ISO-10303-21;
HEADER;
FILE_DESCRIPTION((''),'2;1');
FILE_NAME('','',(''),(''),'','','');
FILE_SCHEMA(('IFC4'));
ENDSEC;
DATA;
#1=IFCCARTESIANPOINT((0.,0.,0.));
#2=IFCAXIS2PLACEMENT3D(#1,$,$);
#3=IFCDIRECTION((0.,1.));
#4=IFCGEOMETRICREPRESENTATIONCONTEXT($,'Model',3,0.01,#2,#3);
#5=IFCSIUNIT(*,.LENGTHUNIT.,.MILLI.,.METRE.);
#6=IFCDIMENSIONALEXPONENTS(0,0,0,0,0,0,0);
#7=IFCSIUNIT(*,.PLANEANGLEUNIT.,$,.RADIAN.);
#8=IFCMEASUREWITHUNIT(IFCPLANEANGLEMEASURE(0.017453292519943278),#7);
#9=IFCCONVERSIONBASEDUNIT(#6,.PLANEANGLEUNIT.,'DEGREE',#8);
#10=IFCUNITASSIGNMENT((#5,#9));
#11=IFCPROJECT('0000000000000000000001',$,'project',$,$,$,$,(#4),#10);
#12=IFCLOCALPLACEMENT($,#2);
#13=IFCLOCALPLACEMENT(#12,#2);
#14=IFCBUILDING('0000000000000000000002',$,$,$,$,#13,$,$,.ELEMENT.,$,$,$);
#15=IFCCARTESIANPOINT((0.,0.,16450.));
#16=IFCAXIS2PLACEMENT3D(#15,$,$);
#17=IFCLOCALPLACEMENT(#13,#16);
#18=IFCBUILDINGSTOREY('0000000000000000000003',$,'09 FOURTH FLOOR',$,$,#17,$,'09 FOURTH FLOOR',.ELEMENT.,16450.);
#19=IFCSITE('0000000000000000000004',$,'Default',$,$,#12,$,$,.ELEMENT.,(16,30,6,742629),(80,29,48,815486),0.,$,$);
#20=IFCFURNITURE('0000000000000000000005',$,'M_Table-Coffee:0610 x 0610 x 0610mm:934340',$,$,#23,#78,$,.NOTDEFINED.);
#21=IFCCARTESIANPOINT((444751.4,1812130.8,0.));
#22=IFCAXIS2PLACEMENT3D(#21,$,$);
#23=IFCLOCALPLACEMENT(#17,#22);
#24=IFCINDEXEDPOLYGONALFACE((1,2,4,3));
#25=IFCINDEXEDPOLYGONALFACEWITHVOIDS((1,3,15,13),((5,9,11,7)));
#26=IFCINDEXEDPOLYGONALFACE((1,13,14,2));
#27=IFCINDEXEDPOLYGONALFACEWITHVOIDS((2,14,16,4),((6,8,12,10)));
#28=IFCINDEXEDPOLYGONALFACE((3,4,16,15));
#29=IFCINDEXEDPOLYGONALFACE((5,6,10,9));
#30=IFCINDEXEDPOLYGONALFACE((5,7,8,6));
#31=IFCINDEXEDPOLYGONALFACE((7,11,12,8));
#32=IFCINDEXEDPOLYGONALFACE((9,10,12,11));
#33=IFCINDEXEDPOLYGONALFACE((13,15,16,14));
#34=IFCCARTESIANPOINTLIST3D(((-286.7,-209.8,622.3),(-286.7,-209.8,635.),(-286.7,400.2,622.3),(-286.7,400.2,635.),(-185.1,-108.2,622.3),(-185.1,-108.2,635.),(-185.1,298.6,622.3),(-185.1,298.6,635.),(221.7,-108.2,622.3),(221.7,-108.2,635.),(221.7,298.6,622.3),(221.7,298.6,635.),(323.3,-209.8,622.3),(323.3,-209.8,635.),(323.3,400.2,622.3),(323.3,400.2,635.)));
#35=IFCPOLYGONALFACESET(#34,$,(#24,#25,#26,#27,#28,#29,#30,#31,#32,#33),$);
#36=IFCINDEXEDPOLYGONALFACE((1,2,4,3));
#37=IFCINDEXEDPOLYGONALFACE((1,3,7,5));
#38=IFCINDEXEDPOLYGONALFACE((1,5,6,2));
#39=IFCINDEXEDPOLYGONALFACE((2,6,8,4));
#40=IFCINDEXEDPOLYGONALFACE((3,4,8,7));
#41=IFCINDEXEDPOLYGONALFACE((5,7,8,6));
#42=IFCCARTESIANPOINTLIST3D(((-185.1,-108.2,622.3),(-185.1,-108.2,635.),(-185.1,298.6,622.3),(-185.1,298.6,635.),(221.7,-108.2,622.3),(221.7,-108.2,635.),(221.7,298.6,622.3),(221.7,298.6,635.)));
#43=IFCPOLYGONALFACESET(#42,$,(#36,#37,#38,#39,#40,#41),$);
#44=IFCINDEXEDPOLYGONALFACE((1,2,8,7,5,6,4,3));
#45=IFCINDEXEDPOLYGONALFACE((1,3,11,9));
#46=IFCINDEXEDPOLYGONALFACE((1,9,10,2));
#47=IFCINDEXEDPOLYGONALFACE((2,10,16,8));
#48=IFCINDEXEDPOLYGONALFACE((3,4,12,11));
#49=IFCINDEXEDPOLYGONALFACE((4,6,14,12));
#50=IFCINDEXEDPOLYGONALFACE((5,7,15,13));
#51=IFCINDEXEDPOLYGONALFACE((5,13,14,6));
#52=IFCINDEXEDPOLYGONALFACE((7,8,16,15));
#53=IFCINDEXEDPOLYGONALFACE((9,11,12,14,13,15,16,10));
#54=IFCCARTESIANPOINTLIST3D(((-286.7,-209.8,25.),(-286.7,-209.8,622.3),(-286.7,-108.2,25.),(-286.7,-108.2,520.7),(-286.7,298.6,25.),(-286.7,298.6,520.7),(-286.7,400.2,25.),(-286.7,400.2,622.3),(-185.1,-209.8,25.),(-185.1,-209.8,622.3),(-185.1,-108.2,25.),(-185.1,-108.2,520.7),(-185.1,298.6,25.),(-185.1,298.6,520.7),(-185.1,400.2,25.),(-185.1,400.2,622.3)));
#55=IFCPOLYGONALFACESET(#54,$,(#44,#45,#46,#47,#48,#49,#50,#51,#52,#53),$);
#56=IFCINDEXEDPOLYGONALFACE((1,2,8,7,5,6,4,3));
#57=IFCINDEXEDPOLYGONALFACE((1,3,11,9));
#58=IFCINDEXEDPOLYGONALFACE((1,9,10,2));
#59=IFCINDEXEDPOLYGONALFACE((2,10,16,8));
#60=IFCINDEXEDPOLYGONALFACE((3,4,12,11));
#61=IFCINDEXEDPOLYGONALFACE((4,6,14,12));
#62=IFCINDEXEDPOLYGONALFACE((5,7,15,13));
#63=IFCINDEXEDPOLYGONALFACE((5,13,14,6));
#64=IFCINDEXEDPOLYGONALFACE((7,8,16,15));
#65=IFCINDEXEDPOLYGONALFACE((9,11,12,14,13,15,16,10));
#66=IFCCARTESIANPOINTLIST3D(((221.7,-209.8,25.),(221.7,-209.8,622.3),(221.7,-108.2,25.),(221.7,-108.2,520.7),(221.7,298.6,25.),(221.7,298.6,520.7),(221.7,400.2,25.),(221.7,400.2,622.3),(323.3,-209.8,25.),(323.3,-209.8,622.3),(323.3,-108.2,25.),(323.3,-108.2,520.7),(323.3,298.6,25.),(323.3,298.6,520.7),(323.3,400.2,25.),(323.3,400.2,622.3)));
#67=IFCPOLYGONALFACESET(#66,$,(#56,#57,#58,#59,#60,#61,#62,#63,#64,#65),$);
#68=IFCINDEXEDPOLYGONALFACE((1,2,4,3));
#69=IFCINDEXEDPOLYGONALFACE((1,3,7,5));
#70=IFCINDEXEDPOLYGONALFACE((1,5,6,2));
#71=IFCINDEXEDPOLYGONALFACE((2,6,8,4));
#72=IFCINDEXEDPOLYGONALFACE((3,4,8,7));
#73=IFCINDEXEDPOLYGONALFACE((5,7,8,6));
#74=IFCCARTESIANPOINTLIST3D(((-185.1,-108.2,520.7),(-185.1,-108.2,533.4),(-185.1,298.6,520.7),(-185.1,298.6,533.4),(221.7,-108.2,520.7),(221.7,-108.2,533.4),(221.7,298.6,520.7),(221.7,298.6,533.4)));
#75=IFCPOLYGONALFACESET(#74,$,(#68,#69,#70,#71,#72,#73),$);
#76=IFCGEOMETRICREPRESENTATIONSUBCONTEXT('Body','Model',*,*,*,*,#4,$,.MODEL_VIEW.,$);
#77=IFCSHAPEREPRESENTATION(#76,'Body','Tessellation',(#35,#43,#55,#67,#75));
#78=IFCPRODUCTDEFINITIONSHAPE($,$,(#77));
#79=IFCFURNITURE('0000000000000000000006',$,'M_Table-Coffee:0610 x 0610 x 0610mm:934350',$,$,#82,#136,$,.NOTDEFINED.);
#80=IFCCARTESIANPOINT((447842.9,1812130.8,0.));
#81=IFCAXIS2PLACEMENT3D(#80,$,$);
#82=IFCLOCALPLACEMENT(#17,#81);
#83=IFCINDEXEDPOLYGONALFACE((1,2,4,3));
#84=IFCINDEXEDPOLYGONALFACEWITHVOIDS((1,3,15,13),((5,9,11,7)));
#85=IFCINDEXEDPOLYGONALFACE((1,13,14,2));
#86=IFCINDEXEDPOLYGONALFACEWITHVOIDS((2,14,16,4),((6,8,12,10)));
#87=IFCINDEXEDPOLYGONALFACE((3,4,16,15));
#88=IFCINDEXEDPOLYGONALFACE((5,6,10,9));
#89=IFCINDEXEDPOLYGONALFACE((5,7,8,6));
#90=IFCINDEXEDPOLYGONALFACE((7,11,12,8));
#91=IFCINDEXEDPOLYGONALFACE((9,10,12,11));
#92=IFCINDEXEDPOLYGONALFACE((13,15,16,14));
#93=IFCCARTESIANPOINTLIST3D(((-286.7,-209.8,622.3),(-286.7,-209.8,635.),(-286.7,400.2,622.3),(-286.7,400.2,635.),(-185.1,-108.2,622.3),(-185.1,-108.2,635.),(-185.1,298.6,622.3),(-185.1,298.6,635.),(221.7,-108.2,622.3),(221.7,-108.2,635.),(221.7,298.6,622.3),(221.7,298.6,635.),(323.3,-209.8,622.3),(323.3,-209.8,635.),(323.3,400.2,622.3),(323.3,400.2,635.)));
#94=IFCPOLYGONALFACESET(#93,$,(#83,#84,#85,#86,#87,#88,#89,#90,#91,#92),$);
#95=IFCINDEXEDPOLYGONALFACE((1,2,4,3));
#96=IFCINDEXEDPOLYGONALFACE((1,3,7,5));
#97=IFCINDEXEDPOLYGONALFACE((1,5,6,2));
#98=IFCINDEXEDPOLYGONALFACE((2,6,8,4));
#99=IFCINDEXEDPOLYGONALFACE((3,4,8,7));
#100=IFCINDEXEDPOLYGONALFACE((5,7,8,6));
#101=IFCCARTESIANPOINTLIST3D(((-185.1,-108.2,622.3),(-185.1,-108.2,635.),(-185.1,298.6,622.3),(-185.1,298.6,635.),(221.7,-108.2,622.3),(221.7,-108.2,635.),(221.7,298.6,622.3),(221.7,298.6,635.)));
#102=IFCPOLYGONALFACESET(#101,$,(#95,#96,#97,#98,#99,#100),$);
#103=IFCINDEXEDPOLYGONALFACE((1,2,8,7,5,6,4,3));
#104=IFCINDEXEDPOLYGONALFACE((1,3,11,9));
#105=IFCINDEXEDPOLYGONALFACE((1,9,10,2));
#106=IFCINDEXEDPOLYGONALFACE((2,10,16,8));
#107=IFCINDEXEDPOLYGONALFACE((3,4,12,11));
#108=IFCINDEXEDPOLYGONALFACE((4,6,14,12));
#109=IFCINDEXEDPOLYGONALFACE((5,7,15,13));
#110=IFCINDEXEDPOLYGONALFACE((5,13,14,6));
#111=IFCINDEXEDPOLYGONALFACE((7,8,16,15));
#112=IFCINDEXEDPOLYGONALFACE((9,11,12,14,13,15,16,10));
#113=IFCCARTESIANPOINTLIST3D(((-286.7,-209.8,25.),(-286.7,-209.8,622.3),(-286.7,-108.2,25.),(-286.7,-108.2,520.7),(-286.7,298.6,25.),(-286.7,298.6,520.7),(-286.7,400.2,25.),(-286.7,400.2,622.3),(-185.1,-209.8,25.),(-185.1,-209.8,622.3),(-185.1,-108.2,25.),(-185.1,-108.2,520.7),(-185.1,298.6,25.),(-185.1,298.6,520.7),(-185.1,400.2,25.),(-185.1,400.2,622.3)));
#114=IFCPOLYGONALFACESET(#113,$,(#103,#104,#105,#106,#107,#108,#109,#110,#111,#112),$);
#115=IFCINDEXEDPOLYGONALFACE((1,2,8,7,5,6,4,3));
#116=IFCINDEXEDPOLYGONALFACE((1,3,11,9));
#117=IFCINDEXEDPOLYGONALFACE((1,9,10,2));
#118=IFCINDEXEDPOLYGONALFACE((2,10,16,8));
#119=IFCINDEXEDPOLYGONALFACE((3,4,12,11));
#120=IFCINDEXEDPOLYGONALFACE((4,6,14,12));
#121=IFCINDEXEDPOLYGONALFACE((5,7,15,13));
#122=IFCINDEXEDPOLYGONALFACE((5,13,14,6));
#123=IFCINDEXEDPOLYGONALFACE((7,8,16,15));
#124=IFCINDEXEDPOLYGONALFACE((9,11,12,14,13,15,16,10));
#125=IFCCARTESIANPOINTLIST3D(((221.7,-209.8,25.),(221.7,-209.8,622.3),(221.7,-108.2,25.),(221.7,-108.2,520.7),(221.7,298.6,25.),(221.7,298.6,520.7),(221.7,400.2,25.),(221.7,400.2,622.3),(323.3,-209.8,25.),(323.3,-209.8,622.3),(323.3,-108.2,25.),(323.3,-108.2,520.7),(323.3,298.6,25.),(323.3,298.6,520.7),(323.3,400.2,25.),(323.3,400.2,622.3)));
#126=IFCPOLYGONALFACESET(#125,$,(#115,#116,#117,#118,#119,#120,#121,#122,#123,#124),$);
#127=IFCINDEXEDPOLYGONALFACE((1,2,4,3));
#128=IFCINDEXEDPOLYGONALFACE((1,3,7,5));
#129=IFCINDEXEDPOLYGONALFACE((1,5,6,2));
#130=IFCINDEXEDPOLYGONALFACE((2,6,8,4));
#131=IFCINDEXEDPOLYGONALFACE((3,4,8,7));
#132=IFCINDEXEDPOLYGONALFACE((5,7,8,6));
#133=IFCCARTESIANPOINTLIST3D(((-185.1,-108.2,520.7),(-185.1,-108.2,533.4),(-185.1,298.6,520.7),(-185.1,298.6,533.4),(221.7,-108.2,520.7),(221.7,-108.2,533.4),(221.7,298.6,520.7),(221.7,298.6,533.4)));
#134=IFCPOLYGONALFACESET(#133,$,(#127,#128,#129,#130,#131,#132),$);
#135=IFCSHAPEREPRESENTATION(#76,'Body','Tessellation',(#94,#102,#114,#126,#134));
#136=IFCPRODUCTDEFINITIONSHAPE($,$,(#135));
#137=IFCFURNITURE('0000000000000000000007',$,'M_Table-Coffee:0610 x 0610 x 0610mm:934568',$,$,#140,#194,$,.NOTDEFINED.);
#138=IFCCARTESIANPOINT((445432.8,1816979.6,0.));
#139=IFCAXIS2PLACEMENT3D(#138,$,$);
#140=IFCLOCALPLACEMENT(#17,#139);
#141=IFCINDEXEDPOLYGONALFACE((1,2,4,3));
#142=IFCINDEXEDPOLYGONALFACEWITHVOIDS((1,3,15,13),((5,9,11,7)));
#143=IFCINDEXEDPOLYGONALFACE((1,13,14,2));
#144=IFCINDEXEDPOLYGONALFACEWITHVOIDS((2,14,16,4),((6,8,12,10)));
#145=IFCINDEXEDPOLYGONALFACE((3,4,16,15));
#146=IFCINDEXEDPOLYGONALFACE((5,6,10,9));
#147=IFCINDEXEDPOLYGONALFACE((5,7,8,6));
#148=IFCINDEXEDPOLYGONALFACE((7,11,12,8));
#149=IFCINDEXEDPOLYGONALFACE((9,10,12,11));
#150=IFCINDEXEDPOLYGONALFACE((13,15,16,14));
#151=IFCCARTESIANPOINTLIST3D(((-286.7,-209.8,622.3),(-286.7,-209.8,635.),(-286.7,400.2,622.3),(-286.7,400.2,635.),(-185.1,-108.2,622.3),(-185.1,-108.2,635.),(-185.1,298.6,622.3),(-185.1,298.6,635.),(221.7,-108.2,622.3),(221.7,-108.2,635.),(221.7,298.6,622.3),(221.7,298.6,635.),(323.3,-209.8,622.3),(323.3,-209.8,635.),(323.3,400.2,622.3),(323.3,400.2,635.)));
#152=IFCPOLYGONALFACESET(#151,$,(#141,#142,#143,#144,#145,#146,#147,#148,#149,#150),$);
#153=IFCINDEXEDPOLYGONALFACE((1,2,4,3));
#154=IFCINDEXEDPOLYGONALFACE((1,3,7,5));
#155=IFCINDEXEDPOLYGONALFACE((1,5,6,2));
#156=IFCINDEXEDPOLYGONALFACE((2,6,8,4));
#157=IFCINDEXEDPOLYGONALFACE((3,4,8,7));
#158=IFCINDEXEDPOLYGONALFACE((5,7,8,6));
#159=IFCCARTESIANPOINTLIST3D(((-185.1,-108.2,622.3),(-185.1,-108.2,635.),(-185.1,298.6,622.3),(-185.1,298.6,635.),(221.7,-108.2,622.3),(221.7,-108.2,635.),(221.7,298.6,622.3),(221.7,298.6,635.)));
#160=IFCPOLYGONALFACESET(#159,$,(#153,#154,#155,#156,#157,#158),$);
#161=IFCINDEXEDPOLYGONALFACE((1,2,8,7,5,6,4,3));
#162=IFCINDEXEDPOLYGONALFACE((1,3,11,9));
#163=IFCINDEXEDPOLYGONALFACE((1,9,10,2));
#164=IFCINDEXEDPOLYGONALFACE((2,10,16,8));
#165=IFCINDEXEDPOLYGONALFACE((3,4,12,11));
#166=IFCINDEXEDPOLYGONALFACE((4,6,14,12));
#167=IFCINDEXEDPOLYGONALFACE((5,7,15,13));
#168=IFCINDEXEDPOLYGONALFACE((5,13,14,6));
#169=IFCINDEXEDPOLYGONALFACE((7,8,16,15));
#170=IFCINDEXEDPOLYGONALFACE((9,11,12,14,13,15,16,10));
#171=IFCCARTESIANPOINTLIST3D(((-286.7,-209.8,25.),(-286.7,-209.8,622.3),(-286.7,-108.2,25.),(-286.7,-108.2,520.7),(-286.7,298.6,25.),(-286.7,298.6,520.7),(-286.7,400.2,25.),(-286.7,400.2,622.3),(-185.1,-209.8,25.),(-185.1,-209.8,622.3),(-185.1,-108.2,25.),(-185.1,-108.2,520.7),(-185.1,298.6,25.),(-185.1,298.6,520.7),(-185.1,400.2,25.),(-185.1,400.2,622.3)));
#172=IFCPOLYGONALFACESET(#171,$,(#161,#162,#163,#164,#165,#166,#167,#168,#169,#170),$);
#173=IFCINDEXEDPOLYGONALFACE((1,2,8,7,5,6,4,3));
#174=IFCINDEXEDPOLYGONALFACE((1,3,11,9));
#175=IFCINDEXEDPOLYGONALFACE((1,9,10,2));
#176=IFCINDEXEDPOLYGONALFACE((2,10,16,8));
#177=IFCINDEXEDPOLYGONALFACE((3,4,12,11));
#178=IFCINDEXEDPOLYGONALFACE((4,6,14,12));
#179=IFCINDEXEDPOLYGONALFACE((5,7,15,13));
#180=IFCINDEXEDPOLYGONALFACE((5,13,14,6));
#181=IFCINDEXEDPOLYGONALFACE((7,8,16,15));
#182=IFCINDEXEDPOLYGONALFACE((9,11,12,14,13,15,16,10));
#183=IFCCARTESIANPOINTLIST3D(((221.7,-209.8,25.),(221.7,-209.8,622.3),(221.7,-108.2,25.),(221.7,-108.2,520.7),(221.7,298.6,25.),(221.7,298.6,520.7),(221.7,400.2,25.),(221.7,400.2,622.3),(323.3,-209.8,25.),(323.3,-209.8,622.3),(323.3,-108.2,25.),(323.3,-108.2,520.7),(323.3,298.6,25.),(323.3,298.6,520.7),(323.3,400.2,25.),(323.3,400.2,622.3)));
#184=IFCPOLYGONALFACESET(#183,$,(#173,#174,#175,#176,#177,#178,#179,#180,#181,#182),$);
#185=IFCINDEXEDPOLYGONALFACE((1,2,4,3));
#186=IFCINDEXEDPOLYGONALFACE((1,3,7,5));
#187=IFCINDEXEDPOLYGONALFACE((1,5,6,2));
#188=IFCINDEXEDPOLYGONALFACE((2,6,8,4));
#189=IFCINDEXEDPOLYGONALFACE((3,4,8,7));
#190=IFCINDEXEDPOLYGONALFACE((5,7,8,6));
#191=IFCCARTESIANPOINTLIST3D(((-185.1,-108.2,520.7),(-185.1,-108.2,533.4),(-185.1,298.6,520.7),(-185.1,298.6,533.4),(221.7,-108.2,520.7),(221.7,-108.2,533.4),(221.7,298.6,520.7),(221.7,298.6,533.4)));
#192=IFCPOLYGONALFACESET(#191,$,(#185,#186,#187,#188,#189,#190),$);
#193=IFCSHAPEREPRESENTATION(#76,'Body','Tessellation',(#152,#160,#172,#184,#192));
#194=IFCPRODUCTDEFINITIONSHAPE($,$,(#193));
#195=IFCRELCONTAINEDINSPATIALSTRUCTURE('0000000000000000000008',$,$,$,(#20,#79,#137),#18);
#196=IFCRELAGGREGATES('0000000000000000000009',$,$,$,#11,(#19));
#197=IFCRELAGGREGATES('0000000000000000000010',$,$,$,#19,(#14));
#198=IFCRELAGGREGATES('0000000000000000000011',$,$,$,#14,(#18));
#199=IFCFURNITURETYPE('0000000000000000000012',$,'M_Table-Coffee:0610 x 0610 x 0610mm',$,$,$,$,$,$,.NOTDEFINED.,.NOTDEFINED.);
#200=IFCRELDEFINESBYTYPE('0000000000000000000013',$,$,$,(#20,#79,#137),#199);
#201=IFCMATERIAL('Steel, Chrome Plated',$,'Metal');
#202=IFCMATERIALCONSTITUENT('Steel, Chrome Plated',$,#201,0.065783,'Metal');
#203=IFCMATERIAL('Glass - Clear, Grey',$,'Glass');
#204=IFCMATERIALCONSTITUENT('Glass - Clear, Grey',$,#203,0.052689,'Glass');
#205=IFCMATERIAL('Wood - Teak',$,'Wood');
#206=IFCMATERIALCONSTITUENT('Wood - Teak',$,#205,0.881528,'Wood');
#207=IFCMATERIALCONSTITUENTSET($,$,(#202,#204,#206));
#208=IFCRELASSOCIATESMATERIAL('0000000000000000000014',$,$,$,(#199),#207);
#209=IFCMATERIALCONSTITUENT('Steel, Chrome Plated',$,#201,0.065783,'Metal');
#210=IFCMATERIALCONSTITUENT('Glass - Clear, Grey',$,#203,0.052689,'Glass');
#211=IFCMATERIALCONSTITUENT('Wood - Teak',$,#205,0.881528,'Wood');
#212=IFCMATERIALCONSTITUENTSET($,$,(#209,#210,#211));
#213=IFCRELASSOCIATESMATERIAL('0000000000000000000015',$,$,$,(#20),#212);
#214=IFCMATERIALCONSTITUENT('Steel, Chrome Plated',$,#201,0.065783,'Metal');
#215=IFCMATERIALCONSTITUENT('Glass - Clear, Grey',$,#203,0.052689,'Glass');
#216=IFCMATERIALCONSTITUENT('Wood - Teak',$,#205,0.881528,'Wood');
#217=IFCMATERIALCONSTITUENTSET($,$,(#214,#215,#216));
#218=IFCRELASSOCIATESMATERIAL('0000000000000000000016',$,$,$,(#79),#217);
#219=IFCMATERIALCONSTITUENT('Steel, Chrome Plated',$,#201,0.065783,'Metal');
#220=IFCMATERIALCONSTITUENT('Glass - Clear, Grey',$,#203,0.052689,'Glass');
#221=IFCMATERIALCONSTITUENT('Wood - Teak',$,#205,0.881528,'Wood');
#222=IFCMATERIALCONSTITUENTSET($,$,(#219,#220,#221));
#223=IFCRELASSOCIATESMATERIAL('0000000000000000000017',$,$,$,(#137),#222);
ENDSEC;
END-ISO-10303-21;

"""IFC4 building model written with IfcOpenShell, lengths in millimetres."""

from ifc_helpers import new_model, entity, si_unit, converted_unit, direction, frame, origin, place, context, subcontext, project, spatial, indexed_curve, outline, extrude, source, transform, mapped, material, constituent, constituent_set, type_object, type_shapes, element, save


model = new_model("IFC4")

# Units and contexts
model_context = context("Model", 3, precision=0.01, world=origin(), true_north=direction((0.0, 1.0)))
body_context = subcontext(model_context, "Body", "Model", "MODEL_VIEW")
ifc_project = project(units=[si_unit("LENGTHUNIT", "METRE", prefix="MILLI"), converted_unit("PLANEANGLEUNIT", "DEGREE", entity("IfcPlaneAngleMeasure", 0.017453292519943278), si_unit("PLANEANGLEUNIT", "RADIAN"), dimensions=[0, 0, 0, 0, 0, 0, 0])], contexts=[model_context])

# Site, building, storey
site_placement = place(None, origin())
site = spatial("IfcSite", under=ifc_project, at=site_placement, Name="Default", CompositionType="ELEMENT", RefLatitude=(16, 30, 6, 742629), RefLongitude=(80, 29, 48, 815486), RefElevation=0.0)
building_placement = place(site_placement, origin())
building = spatial("IfcBuilding", under=site, at=building_placement, CompositionType="ELEMENT")
storey_placement = place(building_placement, frame((0.0, 0.0, 16450.0)))
storey = spatial("IfcBuildingStorey", under=building, at=storey_placement, Name="09 FOURTH FLOOR", LongName="09 FOURTH FLOOR", CompositionType="ELEMENT", Elevation=16450.0)

# Furniture
ifc_material_1 = material(Name="Steel, Chrome Plated", Category="Metal")
ifc_constituent_1 = constituent(ifc_material_1, Name="Steel, Chrome Plated", Category="Metal", fraction=0.065783)
ifc_material_2 = material(Name="Glass - Clear, Grey", Category="Glass")
ifc_constituent_2 = constituent(ifc_material_2, Name="Glass - Clear, Grey", Category="Glass", fraction=0.052689)
ifc_material_3 = material(Name="Wood - Teak", Category="Wood")
ifc_constituent_3 = constituent(ifc_material_3, Name="Wood - Teak", Category="Wood", fraction=0.881528)
ifc_constituent_set_1 = constituent_set(constituents=[ifc_constituent_1, ifc_constituent_2, ifc_constituent_3])
ifc_constituent_4 = constituent(ifc_material_1, Name="Steel, Chrome Plated", Category="Metal", fraction=0.065783)
ifc_constituent_5 = constituent(ifc_material_2, Name="Glass - Clear, Grey", Category="Glass", fraction=0.052689)
ifc_constituent_6 = constituent(ifc_material_3, Name="Wood - Teak", Category="Wood", fraction=0.881528)
ifc_constituent_set_2 = constituent_set(constituents=[ifc_constituent_4, ifc_constituent_5, ifc_constituent_6])
furniture_type_1 = type_object("IfcFurnitureType", Name="M_Table-Coffee:0610 x 0610 x 0610mm", AssemblyPlace="NOTDEFINED", PredefinedType="NOTDEFINED", material=ifc_constituent_set_2)
shared_shape_1 = source(origin(), body_context, "Body", "SweptSolid", [
    extrude(outline(indexed_curve([(-305.0, -305.0), (305.0, -305.0), (305.0, 305.0), (-305.0, 305.0), (-305.0, -305.0)], self_intersect=False), holes=[indexed_curve([(-203.4, -203.4), (-203.4, 203.4), (203.4, 203.4), (203.4, -203.4), (-203.4, -203.4)], self_intersect=False)]), frame((18.3, 95.2, 622.3), z_axis=(0.0, 0.0, 1.0), x_axis=(-1.0, 0.0, 0.0)), (0.0, 0.0, 1.0), 12.7),
    extrude(outline(indexed_curve([(-203.4, -203.4), (203.4, -203.4), (203.4, 203.4), (-203.4, 203.4), (-203.4, -203.4)], self_intersect=False)), frame((18.3, 95.2, 622.3), z_axis=(0.0, 0.0, 1.0), x_axis=(-1.0, 0.0, 0.0)), (0.0, 0.0, 1.0), 12.7),
    extrude(outline(indexed_curve([(-305.0, -324.1), (305.0, -324.1), (305.0, 273.3), (203.4, 273.3), (203.4, -222.4), (-203.4, -222.4), (-203.4, 273.3), (-305.0, 273.3), (-305.0, -324.1)], self_intersect=False)), frame((-286.7, 95.2, 298.3), z_axis=(1.0, 0.0, 0.0), x_axis=(0.0, -1.0, 0.0)), (0.0, 0.0, 1.0), 101.6),
    extrude(outline(indexed_curve([(-273.2, -305.0), (324.0, -305.0), (324.0, 305.0), (-273.2, 305.0), (-273.2, 203.4), (222.5, 203.4), (222.5, -203.4), (-273.2, -203.4), (-273.2, -305.0)], self_intersect=False)), frame((221.7, 95.2, 298.2), z_axis=(1.0, 0.0, 0.0), x_axis=(0.0, 0.0, 1.0)), (0.0, 0.0, 1.0), 101.6),
    extrude(outline(indexed_curve([(-203.4, -203.4), (203.4, -203.4), (203.4, 203.4), (-203.4, 203.4), (-203.4, -203.4)], self_intersect=False)), frame((18.3, 95.2, 520.7), z_axis=(0.0, 0.0, 1.0), x_axis=(-1.0, 0.0, 0.0)), (0.0, 0.0, 1.0), 12.7),
])
type_shapes(furniture_type_1, [shared_shape_1])
furniture_1_placement = place(storey_placement, frame((444751.4, 1812130.8, 0.0)))
element("IfcFurniture", 1, at=furniture_1_placement, inside=storey, type_object=furniture_type_1, material=ifc_constituent_set_1, Name="M_Table-Coffee:0610 x 0610 x 0610mm:934340", PredefinedType="NOTDEFINED", context=body_context, shape_type="MappedRepresentation", body=[
    mapped(shared_shape_1, transform((0.0, 0.0, 0.0), scale=1.0)),
])
ifc_constituent_7 = constituent(ifc_material_1, Name="Steel, Chrome Plated", Category="Metal", fraction=0.065783)
ifc_constituent_8 = constituent(ifc_material_2, Name="Glass - Clear, Grey", Category="Glass", fraction=0.052689)
ifc_constituent_9 = constituent(ifc_material_3, Name="Wood - Teak", Category="Wood", fraction=0.881528)
ifc_constituent_set_3 = constituent_set(constituents=[ifc_constituent_7, ifc_constituent_8, ifc_constituent_9])
furniture_2_placement = place(storey_placement, frame((447842.9, 1812130.8, 0.0)))
element("IfcFurniture", 2, at=furniture_2_placement, inside=storey, type_object=furniture_type_1, material=ifc_constituent_set_3, Name="M_Table-Coffee:0610 x 0610 x 0610mm:934350", PredefinedType="NOTDEFINED", context=body_context, shape_type="MappedRepresentation", body=[
    mapped(shared_shape_1, transform((0.0, 0.0, 0.0), scale=1.0)),
])
ifc_constituent_10 = constituent(ifc_material_1, Name="Steel, Chrome Plated", Category="Metal", fraction=0.065783)
ifc_constituent_11 = constituent(ifc_material_2, Name="Glass - Clear, Grey", Category="Glass", fraction=0.052689)
ifc_constituent_12 = constituent(ifc_material_3, Name="Wood - Teak", Category="Wood", fraction=0.881528)
ifc_constituent_set_4 = constituent_set(constituents=[ifc_constituent_10, ifc_constituent_11, ifc_constituent_12])
furniture_3_placement = place(storey_placement, frame((445432.8, 1816979.6, 0.0)))
element("IfcFurniture", 3, at=furniture_3_placement, inside=storey, type_object=furniture_type_1, material=ifc_constituent_set_4, Name="M_Table-Coffee:0610 x 0610 x 0610mm:934568", PredefinedType="NOTDEFINED", context=body_context, shape_type="MappedRepresentation", body=[
    mapped(shared_shape_1, transform((0.0, 0.0, 0.0), scale=1.0)),
])

save(model, "model.ifc")
